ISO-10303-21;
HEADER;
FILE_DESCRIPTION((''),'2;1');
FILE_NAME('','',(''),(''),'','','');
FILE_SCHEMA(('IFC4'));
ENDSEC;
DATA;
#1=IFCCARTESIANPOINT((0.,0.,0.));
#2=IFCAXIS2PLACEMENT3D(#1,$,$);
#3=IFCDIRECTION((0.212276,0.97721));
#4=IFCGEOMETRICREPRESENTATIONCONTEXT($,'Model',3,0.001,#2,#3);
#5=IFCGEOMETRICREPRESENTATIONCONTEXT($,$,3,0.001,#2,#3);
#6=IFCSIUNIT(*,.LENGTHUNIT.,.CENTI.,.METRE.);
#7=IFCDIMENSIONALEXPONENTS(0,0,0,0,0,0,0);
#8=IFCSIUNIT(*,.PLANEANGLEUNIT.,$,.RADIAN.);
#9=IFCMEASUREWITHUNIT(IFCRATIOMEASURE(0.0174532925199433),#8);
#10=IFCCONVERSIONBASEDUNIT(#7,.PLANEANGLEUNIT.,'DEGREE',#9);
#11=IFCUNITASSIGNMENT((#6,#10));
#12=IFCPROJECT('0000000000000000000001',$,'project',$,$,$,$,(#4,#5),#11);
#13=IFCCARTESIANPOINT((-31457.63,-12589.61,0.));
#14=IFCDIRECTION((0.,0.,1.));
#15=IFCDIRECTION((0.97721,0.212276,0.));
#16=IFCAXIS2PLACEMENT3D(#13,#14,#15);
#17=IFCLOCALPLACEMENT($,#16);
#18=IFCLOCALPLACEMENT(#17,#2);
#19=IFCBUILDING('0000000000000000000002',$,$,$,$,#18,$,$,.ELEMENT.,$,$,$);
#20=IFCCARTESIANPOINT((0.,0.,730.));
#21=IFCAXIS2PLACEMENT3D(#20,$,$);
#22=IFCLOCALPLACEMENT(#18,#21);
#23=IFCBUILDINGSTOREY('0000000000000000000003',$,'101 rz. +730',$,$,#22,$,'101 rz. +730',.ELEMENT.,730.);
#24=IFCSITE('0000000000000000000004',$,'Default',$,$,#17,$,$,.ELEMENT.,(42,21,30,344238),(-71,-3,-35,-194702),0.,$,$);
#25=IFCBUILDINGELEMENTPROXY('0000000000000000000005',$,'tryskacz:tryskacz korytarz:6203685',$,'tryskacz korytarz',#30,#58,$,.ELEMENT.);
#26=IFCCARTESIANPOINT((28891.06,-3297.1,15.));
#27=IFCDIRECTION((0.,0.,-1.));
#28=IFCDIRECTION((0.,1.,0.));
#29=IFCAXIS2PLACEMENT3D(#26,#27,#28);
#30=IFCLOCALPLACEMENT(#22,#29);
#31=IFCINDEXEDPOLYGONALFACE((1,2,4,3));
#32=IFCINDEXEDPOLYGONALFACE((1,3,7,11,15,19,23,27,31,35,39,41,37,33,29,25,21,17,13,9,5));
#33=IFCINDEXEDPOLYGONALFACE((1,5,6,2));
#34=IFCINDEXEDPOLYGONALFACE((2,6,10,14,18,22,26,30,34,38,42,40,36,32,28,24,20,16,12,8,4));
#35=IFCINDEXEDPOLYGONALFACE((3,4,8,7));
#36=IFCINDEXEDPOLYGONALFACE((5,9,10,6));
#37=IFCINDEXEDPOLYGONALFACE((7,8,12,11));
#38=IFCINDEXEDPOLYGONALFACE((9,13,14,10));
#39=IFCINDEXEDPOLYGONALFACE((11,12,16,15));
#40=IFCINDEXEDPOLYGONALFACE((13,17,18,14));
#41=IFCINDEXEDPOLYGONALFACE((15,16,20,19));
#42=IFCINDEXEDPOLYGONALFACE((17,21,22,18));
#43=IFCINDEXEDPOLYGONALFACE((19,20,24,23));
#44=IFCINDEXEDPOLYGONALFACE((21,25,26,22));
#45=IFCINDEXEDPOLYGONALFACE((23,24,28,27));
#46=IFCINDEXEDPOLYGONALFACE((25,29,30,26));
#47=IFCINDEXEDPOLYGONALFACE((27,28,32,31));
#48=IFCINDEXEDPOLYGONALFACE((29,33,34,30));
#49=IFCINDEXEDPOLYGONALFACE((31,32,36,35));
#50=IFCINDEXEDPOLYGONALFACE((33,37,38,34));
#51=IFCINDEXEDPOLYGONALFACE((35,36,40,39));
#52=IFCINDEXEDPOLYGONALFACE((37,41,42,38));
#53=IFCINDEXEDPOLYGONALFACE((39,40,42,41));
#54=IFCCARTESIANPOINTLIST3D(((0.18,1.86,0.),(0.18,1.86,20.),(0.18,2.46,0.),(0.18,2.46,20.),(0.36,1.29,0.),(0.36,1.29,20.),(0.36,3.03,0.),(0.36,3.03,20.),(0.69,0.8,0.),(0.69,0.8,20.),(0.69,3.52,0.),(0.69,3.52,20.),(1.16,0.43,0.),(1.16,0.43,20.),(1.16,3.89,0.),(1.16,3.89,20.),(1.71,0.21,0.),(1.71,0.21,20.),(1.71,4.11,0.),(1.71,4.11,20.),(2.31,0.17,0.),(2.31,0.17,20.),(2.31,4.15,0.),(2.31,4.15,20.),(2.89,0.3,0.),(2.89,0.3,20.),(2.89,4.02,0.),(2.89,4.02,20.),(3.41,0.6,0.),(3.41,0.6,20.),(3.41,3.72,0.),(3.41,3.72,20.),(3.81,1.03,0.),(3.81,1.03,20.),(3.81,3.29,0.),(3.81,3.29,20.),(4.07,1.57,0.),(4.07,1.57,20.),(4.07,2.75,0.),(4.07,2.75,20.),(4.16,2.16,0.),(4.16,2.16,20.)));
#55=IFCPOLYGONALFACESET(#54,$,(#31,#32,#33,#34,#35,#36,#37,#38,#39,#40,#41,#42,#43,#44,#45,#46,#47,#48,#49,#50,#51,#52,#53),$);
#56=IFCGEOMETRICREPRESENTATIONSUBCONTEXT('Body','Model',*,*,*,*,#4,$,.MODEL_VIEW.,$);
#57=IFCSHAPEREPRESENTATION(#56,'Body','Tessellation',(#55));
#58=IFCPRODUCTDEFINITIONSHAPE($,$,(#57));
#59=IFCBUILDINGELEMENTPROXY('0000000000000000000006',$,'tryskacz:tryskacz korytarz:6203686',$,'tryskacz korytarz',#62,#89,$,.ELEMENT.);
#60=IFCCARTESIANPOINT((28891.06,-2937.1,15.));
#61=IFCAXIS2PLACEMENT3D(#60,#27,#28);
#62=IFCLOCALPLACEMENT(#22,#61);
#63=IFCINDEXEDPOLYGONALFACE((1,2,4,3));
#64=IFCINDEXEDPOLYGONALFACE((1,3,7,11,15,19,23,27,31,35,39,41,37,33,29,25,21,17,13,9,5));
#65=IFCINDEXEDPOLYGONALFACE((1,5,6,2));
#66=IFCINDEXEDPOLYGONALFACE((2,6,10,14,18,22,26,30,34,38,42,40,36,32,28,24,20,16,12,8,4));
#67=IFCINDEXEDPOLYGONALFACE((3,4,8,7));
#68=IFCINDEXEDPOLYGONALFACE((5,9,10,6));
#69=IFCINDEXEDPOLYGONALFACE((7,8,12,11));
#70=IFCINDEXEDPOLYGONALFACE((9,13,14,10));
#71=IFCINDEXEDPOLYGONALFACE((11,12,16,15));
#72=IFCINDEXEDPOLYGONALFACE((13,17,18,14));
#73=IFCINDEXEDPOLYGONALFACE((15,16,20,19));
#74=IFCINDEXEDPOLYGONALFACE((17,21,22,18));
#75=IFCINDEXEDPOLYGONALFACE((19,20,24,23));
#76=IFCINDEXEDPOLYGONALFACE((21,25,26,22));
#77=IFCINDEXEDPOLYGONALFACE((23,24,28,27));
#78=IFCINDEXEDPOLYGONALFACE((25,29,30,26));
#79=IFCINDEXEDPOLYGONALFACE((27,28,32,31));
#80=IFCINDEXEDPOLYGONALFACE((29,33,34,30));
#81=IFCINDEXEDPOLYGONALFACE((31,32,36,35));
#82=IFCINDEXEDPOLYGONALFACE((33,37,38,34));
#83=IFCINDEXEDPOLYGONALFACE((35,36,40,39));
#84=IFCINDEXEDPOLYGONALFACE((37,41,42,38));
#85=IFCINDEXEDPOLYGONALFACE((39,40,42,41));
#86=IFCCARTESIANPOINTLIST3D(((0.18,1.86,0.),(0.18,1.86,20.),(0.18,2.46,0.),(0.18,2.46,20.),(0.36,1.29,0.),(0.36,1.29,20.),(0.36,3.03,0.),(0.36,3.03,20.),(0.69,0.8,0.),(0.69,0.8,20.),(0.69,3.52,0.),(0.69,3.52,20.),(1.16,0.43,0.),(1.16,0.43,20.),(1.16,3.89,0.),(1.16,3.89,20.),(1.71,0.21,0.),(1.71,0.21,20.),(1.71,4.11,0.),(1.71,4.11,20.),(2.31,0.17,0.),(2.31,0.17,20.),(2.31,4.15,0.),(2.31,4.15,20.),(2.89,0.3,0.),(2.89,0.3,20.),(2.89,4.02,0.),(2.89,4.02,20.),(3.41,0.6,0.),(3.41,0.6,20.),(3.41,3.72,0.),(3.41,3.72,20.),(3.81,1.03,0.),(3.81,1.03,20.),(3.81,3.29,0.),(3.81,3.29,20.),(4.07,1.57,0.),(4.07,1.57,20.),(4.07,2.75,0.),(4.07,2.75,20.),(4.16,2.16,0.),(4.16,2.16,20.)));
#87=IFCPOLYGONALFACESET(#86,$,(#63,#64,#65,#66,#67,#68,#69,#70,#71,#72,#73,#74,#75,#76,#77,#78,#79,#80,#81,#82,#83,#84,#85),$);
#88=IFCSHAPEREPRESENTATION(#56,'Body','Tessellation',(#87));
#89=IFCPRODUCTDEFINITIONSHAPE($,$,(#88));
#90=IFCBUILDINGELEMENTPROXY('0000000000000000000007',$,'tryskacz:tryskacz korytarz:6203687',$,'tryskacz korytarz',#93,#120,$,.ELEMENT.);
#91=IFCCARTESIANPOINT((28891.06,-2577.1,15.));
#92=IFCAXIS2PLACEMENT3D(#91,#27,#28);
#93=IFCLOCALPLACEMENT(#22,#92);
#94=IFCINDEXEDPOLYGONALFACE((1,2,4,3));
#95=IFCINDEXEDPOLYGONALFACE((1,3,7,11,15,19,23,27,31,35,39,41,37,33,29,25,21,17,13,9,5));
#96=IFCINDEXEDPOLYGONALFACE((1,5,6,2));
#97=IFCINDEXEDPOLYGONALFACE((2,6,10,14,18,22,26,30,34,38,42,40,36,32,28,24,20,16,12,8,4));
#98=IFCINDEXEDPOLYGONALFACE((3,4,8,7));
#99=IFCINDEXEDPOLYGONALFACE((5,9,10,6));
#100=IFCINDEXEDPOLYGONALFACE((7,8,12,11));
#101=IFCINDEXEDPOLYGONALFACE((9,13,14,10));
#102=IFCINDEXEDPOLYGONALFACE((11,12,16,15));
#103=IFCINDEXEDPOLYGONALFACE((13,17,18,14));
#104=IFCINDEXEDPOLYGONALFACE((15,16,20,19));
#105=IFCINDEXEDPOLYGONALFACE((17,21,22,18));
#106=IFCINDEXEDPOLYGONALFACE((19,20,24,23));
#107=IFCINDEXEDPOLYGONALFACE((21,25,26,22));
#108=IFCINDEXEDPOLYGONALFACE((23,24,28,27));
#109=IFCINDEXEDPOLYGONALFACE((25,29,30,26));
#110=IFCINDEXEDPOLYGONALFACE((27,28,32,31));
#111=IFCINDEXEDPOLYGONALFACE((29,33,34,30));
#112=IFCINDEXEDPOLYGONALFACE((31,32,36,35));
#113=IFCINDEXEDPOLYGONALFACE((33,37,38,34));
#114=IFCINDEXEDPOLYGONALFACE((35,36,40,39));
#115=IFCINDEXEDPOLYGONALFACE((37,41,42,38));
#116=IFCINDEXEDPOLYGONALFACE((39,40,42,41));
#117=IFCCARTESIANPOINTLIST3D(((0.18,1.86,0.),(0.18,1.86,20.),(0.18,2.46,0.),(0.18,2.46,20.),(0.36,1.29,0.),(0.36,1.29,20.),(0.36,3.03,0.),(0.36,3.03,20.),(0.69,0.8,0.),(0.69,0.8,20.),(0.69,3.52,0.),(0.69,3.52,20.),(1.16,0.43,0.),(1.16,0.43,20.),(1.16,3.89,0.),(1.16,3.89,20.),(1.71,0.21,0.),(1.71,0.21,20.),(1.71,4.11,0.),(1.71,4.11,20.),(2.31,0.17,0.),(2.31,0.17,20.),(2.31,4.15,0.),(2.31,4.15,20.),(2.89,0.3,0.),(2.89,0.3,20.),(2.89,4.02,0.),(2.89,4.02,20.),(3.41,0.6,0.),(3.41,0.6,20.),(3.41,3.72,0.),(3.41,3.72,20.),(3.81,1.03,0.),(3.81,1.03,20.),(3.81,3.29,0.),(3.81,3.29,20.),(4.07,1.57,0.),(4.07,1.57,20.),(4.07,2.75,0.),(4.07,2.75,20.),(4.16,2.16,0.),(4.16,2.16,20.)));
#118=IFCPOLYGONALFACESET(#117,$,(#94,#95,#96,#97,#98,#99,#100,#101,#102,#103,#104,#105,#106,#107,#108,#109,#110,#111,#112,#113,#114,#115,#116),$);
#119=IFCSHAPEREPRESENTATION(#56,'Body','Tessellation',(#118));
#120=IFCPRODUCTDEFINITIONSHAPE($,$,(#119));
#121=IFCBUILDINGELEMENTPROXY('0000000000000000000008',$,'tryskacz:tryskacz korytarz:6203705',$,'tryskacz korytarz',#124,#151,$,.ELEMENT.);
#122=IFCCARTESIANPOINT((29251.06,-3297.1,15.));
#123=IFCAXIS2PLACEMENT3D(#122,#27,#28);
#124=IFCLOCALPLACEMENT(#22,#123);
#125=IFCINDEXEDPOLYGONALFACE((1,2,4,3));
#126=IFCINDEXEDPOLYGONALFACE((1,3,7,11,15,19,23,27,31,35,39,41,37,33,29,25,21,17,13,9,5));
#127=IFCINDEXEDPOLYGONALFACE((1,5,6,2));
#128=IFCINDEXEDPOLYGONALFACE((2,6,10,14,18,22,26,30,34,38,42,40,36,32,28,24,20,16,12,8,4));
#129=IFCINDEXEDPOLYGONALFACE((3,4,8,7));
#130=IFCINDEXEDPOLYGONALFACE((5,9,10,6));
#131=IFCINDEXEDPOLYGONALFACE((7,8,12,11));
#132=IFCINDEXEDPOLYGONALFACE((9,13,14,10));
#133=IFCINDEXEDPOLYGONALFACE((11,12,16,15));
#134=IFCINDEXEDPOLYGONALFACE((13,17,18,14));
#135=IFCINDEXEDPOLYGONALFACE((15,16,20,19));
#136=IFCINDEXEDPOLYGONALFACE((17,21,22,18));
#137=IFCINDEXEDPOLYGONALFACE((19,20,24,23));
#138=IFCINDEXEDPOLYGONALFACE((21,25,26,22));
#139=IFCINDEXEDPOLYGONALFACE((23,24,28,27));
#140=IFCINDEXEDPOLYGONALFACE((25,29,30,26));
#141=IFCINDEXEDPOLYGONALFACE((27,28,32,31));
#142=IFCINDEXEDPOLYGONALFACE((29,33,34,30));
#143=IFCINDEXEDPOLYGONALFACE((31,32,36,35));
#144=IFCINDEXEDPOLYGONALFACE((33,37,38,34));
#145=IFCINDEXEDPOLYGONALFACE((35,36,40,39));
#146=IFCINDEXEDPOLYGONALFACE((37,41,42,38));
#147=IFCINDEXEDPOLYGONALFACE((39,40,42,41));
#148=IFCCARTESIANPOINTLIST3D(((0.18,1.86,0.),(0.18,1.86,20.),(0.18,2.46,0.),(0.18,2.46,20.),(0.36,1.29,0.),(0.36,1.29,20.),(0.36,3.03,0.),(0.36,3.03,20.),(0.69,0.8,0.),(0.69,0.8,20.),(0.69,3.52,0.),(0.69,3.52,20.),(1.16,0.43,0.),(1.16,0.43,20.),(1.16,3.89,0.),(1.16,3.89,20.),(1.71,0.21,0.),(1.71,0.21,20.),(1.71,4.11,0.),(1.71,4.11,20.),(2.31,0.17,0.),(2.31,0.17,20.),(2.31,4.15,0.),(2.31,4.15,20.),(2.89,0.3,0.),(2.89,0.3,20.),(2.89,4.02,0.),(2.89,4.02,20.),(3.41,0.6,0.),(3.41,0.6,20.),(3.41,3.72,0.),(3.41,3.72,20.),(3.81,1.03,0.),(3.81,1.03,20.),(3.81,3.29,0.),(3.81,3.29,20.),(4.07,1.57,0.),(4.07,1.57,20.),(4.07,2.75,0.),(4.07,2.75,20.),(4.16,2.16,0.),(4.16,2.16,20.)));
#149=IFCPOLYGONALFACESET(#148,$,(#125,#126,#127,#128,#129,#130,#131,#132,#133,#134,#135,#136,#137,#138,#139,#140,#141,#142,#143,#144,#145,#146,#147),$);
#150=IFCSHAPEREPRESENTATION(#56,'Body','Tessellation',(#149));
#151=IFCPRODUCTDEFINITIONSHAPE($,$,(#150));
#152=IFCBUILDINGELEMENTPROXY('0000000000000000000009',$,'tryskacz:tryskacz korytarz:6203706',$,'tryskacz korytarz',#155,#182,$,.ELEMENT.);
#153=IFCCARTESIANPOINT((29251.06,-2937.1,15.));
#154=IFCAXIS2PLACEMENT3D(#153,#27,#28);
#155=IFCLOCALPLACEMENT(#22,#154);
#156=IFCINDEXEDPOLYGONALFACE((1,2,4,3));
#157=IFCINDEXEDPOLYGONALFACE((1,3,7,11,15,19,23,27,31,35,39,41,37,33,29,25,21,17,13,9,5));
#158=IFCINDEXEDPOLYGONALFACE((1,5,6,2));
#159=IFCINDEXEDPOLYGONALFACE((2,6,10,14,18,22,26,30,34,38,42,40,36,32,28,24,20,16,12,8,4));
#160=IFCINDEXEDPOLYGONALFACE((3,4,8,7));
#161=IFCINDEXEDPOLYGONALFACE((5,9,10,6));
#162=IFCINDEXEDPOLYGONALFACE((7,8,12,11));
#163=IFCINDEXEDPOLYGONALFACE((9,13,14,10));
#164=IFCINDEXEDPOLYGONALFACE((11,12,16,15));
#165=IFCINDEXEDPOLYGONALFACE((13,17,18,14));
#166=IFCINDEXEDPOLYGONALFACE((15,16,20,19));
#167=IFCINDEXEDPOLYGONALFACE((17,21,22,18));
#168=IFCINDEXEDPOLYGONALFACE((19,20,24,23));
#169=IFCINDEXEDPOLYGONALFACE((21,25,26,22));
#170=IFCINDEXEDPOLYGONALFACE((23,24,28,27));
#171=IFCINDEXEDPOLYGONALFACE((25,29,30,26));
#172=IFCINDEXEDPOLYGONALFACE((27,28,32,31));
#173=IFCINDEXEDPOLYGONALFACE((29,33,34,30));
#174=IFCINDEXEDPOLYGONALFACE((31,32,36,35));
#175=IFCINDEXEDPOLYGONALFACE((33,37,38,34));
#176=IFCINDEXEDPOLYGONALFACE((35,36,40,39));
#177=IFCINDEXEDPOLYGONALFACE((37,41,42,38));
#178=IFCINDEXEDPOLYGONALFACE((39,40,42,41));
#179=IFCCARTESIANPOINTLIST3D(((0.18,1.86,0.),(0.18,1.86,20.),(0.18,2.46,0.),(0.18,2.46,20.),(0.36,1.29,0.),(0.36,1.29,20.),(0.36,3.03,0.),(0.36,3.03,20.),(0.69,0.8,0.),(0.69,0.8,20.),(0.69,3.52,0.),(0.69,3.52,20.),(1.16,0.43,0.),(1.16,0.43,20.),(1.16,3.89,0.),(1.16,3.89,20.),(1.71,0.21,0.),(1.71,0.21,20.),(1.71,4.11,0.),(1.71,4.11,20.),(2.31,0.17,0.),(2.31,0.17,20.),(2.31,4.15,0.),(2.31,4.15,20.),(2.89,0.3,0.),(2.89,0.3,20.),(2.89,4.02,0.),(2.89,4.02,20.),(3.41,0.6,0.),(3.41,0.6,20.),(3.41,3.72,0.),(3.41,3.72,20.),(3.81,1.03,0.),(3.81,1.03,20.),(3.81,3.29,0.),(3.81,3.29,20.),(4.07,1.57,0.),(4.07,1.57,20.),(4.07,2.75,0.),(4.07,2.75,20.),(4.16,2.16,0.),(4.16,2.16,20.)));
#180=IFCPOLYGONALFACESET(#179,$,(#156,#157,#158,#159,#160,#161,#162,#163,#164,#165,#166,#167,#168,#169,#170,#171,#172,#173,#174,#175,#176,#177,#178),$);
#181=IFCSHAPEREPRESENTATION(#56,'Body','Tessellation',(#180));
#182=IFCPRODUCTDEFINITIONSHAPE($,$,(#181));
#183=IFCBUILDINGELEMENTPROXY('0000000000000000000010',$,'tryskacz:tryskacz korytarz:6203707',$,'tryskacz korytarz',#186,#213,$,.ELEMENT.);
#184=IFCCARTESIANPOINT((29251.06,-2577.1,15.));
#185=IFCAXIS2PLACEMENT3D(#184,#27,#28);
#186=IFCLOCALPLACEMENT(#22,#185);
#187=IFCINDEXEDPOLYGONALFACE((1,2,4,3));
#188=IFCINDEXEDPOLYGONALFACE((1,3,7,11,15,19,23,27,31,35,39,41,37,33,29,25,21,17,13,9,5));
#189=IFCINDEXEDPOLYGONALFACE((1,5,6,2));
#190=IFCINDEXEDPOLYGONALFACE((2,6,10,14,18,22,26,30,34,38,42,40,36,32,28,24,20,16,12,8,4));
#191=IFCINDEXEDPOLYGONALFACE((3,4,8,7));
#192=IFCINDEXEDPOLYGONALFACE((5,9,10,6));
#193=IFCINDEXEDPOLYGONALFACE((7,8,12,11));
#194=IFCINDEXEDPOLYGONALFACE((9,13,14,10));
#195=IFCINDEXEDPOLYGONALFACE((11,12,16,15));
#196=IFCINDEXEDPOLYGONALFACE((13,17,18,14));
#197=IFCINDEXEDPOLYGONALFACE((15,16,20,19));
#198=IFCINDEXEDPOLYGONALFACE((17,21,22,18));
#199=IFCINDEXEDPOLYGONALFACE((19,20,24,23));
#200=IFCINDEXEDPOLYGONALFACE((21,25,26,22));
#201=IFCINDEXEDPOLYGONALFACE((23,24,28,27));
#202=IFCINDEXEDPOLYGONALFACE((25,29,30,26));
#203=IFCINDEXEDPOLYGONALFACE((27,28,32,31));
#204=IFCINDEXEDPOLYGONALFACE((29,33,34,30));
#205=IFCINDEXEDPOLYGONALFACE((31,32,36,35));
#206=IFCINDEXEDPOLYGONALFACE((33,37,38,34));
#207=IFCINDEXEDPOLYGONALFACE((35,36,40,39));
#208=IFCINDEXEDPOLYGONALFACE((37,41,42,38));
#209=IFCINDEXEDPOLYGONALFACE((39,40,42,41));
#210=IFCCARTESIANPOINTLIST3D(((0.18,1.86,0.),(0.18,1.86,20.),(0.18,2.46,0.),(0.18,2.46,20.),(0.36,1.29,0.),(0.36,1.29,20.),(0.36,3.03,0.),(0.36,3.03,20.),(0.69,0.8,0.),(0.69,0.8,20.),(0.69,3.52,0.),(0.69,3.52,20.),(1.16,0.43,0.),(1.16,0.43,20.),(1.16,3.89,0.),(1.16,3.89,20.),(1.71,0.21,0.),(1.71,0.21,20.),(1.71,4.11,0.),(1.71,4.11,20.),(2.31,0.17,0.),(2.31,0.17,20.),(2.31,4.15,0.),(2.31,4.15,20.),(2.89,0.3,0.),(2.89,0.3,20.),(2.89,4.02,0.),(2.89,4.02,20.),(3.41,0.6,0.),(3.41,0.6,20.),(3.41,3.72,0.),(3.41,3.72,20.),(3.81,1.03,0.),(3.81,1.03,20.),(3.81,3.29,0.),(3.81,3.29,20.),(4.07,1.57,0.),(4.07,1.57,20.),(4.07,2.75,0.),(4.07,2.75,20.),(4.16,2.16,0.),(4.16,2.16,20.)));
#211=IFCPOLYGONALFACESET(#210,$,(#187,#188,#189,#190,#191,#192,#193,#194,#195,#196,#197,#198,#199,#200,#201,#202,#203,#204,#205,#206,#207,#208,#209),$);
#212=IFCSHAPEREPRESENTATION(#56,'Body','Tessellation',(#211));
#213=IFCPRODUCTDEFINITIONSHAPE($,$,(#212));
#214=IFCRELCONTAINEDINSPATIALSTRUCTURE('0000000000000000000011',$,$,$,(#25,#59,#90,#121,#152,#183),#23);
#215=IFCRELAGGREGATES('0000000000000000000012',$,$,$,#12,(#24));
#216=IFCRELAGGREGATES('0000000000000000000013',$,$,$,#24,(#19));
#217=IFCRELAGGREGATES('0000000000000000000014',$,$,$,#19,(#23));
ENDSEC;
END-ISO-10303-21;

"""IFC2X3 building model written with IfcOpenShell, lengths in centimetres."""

from ifc_helpers import new_model, entity, si_unit, converted_unit, direction, frame, frame_2d, origin, place, context, subcontext, project, spatial, circle, extrude, source, transform, mapped, element, save


model = new_model("IFC2X3")

# Units and contexts
model_context = context("Model", 3, precision=0.001, world=origin(), true_north=direction((0.212276, 0.97721)))
context_of_model = context(None, 3, precision=0.001, world=origin(), true_north=direction((0.212276, 0.97721)))
body_context = subcontext(model_context, "Body", "Model", "MODEL_VIEW")
ifc_project = project(units=[si_unit("LENGTHUNIT", "METRE", prefix="CENTI"), converted_unit("PLANEANGLEUNIT", "DEGREE", entity("IfcRatioMeasure", 0.0174532925199433), si_unit("PLANEANGLEUNIT", "RADIAN"), dimensions=[0, 0, 0, 0, 0, 0, 0])], contexts=[model_context, context_of_model])

# Site, building, storey
site_placement = place(None, frame((-31457.63, -12589.61, 0.0), z_axis=(0.0, 0.0, 1.0), x_axis=(0.97721, 0.212276, 0.0)))
site = spatial("IfcSite", under=ifc_project, at=site_placement, Name="Default", CompositionType="ELEMENT", RefLatitude=(42, 21, 30, 344238), RefLongitude=(-71, -3, -35, -194702), RefElevation=0.0)
building_placement = place(site_placement, origin())
building = spatial("IfcBuilding", under=site, at=building_placement, CompositionType="ELEMENT")
storey_placement = place(building_placement, frame((0.0, 0.0, 730.0)))
storey = spatial("IfcBuildingStorey", under=building, at=storey_placement, Name="101 rz. +730", LongName="101 rz. +730", CompositionType="ELEMENT", Elevation=730.0)

# Building element proxies
shared_shape_1 = source(origin(), body_context, "Body", "SweptSolid", [
    extrude(circle(Radius=2.0, at=frame_2d((0.0, 0.0), x_axis=(1.0, 0.0))), frame((2.16, 2.16, 0.0)), (0.0, 0.0, 1.0), 20.0),
])
for number, where, z_axis, x_axis, name in (
    (1, (28891.06, -3297.1, 15.0), (0.0, 0.0, -1.0), (0.0, 1.0, 0.0), "tryskacz:tryskacz korytarz:6203685"),
    (2, (28891.06, -2937.1, 15.0), (0.0, 0.0, -1.0), (0.0, 1.0, 0.0), "tryskacz:tryskacz korytarz:6203686"),
    (3, (28891.06, -2577.1, 15.0), (0.0, 0.0, -1.0), (0.0, 1.0, 0.0), "tryskacz:tryskacz korytarz:6203687"),
    (4, (29251.06, -3297.1, 15.0), (0.0, 0.0, -1.0), (0.0, 1.0, 0.0), "tryskacz:tryskacz korytarz:6203705"),
    (5, (29251.06, -2937.1, 15.0), (0.0, 0.0, -1.0), (0.0, 1.0, 0.0), "tryskacz:tryskacz korytarz:6203706"),
    (6, (29251.06, -2577.1, 15.0), (0.0, 0.0, -1.0), (0.0, 1.0, 0.0), "tryskacz:tryskacz korytarz:6203707"),
):
    element("IfcBuildingElementProxy", number, at=place(storey_placement, frame(where, z_axis=z_axis, x_axis=x_axis)), inside=storey, Name=name, ObjectType="tryskacz korytarz", CompositionType="ELEMENT", context=body_context, shape_type="MappedRepresentation", body=[
        mapped(shared_shape_1, transform((0.0, 0.0, 0.0), scale=1.0)),
    ])

save(model, "model.ifc")
